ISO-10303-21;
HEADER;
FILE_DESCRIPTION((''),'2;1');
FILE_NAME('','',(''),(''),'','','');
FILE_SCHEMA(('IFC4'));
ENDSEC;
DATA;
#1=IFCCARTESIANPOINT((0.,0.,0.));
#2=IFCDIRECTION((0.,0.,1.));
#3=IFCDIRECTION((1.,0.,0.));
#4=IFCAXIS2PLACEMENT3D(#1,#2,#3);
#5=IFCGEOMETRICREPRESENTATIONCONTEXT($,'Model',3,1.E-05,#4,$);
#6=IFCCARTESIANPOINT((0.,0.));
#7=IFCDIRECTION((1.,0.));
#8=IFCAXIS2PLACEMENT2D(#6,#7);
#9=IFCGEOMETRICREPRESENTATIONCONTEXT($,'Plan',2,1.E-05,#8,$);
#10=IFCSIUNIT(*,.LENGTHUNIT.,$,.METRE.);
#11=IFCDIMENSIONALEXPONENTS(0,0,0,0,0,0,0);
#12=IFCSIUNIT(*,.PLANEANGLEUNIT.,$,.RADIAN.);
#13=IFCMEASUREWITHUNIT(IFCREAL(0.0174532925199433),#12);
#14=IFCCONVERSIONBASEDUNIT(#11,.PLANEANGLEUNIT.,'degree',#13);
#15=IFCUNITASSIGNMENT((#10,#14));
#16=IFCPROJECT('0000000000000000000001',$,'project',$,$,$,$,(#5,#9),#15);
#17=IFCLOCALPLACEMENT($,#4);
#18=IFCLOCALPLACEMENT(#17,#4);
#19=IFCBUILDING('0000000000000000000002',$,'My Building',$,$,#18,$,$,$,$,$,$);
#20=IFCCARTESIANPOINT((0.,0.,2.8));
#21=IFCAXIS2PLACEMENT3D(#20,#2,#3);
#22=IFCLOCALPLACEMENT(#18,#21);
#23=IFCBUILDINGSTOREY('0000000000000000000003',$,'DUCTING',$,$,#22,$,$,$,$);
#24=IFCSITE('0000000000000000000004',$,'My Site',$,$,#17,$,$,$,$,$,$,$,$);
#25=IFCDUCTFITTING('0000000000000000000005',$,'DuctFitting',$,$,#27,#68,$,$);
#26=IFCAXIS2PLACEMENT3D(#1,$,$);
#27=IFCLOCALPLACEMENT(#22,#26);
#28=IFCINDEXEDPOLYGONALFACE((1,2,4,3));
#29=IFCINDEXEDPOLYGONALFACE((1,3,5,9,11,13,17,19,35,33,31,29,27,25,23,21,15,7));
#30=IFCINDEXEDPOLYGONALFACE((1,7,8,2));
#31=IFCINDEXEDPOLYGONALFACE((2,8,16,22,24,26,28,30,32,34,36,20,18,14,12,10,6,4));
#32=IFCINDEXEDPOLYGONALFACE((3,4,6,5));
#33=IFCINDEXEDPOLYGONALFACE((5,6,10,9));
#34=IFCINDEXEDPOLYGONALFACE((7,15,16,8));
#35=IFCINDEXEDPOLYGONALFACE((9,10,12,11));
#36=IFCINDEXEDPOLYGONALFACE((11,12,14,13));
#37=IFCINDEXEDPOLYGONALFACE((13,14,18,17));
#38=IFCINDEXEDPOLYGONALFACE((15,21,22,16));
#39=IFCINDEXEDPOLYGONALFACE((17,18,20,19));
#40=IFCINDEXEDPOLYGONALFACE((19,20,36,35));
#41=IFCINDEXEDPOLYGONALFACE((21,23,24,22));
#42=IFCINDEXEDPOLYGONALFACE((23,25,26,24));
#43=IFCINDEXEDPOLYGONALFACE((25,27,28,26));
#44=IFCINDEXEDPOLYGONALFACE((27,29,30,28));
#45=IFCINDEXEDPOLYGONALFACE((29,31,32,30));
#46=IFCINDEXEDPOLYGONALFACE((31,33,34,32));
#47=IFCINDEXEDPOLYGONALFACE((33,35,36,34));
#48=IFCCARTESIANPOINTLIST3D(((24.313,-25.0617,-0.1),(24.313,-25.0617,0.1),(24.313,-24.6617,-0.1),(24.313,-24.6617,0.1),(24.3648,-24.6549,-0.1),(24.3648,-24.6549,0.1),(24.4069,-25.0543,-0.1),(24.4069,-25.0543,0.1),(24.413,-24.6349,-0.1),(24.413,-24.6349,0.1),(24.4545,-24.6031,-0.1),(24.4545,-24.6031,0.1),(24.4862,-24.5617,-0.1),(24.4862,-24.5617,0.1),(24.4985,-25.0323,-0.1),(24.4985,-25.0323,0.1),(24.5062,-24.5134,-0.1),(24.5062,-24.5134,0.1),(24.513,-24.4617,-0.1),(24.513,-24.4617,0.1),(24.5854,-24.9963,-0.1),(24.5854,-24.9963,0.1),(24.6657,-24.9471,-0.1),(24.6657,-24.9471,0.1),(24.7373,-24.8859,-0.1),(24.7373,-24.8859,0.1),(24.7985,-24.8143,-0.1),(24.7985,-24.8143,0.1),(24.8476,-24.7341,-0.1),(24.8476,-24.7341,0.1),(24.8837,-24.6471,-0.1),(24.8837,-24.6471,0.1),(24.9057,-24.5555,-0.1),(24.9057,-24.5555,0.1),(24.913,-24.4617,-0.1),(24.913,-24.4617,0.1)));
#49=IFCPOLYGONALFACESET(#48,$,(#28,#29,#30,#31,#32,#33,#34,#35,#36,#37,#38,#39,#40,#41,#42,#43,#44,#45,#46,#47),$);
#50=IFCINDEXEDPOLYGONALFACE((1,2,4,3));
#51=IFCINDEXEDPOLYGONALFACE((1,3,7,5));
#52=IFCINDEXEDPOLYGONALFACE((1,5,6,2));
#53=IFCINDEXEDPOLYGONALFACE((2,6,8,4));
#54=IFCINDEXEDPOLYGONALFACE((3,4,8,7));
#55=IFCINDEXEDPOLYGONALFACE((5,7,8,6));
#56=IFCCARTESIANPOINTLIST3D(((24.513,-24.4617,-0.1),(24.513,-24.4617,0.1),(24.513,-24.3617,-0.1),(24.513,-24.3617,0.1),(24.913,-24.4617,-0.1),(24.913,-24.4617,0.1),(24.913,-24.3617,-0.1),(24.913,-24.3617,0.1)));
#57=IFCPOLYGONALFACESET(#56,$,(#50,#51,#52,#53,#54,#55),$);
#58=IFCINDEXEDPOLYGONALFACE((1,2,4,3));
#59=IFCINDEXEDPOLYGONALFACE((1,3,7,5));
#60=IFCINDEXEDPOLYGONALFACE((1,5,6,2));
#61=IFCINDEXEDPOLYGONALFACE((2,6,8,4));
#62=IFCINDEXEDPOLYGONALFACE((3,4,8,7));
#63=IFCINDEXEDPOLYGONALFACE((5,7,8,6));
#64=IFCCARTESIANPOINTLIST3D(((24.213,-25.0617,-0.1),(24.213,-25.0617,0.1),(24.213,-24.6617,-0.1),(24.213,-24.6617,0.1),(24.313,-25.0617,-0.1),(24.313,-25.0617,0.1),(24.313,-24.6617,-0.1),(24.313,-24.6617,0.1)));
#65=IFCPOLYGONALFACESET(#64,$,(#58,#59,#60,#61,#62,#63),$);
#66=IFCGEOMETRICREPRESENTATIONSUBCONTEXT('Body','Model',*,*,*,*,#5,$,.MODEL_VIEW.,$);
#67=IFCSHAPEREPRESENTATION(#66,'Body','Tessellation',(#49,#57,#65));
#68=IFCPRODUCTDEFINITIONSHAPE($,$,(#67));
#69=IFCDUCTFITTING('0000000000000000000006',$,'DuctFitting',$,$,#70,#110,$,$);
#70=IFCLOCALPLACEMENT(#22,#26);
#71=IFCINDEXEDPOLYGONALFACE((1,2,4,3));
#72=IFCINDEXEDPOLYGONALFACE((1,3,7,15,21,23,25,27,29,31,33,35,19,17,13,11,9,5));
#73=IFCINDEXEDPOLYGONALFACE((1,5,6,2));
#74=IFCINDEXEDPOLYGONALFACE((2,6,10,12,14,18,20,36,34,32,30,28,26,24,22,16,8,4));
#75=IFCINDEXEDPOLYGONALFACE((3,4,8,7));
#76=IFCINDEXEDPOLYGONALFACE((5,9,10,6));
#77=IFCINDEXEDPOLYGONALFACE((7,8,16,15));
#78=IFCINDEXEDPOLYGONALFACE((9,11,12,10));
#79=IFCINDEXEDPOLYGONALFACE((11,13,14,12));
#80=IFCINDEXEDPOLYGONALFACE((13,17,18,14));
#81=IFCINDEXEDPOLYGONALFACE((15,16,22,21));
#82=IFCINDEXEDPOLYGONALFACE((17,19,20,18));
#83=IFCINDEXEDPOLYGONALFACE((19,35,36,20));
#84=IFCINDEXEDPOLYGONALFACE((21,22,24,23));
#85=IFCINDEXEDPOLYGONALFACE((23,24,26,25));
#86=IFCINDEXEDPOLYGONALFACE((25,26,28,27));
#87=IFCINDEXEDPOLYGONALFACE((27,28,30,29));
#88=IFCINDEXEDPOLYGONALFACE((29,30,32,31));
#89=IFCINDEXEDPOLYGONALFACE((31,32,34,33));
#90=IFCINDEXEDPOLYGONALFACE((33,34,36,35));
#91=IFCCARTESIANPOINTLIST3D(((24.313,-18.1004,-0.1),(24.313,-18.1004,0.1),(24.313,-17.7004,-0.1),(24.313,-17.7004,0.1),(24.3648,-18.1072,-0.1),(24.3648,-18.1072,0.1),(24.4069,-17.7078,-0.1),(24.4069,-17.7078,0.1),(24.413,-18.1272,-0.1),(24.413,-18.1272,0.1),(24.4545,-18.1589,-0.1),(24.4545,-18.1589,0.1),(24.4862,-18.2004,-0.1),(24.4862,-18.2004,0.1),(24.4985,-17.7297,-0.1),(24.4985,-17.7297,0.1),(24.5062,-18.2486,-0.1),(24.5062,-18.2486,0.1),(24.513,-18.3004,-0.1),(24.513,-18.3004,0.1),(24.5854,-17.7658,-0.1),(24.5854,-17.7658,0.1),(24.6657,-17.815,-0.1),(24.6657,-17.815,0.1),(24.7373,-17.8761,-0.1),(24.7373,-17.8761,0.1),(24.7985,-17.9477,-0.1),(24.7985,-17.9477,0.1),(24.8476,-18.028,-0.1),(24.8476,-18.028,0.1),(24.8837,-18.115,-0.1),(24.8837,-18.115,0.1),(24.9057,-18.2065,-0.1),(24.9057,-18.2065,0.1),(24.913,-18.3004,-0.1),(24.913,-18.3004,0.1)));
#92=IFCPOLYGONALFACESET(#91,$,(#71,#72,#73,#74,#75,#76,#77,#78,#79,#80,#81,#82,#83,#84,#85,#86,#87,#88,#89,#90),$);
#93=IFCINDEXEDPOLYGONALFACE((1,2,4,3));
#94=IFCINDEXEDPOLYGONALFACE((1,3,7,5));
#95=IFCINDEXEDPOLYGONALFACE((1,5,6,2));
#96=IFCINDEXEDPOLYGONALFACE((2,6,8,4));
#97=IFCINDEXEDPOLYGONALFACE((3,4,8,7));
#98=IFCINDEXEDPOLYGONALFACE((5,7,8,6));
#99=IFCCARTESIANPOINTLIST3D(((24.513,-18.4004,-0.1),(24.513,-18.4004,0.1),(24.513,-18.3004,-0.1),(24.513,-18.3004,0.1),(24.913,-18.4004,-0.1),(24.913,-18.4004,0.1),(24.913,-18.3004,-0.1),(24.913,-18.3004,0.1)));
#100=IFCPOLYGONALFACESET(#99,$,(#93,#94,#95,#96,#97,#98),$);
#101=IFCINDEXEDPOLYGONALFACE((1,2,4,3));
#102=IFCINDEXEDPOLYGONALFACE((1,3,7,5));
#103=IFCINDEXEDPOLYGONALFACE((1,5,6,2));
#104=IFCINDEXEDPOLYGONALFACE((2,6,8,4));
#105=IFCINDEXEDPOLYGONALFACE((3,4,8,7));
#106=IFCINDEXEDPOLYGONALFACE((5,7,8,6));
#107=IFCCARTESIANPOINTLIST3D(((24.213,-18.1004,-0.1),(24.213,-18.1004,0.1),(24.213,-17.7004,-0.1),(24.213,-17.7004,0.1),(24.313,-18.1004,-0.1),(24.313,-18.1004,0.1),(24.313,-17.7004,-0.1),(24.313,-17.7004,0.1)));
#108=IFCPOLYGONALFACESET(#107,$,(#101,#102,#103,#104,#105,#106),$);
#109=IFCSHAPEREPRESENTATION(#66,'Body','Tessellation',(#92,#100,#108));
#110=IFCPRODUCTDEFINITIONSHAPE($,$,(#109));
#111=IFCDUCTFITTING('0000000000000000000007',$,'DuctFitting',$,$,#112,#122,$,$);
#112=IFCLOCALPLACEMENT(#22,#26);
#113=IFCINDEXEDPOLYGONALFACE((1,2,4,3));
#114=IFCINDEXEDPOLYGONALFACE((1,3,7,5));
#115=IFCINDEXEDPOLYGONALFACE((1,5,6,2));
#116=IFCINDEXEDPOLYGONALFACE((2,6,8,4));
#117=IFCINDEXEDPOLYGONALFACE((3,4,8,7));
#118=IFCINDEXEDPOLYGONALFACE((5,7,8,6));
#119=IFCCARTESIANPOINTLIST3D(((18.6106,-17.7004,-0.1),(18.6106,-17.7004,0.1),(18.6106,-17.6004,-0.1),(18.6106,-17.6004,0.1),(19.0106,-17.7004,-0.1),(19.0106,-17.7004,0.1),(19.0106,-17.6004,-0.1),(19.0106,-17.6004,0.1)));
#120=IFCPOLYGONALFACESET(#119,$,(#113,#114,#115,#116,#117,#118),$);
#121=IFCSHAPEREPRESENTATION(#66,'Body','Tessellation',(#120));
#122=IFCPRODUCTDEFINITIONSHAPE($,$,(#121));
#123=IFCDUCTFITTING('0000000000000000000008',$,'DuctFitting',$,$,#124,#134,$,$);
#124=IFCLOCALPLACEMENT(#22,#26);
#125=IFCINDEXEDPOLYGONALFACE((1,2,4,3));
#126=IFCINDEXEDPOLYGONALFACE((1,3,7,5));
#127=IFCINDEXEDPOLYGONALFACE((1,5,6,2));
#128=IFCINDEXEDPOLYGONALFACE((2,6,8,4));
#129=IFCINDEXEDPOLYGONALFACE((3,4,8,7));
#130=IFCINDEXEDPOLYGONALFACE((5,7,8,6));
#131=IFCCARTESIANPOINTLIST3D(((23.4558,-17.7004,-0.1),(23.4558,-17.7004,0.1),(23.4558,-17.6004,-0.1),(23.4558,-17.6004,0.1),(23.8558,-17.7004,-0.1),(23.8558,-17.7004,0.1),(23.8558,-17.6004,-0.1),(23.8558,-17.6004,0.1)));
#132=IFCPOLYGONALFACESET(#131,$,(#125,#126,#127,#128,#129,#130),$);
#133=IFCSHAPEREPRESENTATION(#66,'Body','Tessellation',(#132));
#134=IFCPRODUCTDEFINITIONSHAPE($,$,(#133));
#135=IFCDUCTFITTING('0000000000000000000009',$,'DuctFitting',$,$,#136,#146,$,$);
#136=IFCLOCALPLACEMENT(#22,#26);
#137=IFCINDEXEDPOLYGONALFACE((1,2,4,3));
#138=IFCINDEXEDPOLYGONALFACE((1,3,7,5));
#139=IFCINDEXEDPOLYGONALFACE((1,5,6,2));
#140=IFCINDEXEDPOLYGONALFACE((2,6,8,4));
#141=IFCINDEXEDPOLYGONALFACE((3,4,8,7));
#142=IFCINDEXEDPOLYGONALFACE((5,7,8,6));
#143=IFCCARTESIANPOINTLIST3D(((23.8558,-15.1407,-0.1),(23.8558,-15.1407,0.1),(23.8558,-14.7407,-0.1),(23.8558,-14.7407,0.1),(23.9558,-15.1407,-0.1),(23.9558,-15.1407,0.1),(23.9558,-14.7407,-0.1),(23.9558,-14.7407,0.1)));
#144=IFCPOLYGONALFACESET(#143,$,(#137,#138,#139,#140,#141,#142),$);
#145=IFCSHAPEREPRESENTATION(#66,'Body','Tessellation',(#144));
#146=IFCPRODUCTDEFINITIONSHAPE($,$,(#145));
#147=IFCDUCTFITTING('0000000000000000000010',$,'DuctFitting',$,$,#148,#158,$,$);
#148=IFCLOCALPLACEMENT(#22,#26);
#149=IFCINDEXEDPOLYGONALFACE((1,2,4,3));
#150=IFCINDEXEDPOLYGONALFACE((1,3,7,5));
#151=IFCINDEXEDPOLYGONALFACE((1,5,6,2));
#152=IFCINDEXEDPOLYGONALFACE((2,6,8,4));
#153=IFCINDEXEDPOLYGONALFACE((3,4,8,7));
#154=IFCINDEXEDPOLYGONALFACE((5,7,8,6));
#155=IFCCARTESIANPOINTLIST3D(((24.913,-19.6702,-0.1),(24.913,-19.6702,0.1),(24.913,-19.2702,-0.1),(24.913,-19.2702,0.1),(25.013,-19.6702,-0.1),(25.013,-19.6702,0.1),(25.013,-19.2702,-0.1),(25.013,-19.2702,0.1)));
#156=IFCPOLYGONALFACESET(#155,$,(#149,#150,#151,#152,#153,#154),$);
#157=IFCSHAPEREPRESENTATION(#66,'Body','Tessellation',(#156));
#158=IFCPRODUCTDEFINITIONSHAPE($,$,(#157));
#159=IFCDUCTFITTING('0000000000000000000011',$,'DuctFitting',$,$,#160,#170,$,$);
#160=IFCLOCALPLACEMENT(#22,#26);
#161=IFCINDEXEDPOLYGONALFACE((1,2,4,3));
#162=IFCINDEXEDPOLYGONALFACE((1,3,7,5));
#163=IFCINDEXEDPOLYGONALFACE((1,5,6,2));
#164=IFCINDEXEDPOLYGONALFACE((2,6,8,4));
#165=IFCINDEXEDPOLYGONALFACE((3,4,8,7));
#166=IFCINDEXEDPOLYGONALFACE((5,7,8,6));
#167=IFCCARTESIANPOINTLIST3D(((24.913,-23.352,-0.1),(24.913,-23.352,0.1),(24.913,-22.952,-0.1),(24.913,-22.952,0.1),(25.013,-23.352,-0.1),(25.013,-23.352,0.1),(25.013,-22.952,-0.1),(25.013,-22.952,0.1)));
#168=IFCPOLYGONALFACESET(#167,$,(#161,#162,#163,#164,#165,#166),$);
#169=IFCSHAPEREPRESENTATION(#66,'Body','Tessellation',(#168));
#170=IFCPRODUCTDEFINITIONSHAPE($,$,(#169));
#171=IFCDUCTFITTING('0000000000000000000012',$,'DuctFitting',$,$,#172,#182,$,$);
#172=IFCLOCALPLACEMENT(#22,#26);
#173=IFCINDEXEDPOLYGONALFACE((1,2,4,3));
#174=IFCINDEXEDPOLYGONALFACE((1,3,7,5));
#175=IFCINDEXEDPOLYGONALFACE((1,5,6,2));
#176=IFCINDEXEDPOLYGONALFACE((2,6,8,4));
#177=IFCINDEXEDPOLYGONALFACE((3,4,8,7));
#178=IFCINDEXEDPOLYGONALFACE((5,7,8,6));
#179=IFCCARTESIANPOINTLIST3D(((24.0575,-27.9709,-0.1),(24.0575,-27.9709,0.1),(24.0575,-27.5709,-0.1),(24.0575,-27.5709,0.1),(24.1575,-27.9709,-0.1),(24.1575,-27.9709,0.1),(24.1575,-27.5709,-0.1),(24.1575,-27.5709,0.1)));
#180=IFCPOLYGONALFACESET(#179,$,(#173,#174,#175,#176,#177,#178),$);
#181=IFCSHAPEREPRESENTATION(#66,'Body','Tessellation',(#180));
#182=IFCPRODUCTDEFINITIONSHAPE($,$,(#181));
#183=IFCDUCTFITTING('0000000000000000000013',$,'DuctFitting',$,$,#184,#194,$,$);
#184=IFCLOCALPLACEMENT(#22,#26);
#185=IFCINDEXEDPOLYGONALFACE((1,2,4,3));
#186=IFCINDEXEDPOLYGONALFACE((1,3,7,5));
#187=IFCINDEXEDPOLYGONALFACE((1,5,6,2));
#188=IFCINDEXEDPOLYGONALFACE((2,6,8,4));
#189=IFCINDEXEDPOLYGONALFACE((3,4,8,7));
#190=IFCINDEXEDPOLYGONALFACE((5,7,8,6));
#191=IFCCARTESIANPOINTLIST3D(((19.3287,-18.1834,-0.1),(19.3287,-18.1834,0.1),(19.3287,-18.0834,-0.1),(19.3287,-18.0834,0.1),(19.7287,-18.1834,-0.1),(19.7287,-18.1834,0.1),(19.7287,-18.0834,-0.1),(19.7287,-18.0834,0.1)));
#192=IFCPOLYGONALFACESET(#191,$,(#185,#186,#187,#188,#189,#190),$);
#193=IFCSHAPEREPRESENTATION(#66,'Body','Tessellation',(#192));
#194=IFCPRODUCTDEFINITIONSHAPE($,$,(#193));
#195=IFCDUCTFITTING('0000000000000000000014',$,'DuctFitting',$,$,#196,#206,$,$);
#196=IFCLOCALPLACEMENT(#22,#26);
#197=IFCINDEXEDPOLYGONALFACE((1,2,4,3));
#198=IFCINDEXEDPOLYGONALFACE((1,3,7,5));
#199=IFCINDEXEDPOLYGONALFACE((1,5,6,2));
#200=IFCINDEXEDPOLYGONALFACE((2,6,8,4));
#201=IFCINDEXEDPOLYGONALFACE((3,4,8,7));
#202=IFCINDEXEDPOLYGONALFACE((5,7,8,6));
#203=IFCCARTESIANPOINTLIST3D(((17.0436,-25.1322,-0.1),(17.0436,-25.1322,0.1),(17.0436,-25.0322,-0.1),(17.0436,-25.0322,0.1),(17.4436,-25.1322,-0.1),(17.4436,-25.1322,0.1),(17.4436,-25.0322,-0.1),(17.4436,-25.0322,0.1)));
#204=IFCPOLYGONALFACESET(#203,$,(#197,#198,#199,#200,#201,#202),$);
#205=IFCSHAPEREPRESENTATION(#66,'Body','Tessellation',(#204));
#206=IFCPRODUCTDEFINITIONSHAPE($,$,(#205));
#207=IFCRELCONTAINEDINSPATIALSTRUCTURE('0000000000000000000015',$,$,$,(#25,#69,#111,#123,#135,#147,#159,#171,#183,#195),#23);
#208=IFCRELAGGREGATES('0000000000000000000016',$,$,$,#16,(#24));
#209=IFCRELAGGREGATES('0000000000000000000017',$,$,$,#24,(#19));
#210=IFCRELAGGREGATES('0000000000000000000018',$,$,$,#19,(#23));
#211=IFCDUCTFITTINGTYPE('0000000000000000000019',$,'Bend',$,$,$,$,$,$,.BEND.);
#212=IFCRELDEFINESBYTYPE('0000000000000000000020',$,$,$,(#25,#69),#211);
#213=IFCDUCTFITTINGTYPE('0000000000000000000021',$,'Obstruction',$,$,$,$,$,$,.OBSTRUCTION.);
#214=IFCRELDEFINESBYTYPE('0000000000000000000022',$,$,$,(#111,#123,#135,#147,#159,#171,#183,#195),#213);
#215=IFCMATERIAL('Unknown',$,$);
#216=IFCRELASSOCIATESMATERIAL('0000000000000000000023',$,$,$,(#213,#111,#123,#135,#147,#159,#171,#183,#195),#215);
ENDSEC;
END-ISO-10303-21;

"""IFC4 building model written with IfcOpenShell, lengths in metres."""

from ifc_helpers import new_model, entity, si_unit, converted_unit, frame, origin_with_axes, origin_2d_with_axis, place, context, subcontext, project, spatial, line, arc, indexed_curve, rectangle, outline, extrude, source, transform, mapped, material, material_profile, profile_set, profile_usage, type_object, type_shapes, element, save


model = new_model("IFC4")

# Units and contexts
model_context = context("Model", 3, precision=1e-05, world=origin_with_axes())
plan_context = context("Plan", 2, precision=1e-05, world=origin_2d_with_axis())
body_context = subcontext(model_context, "Body", "Model", "MODEL_VIEW")
ifc_project = project(units=[si_unit("LENGTHUNIT", "METRE"), converted_unit("PLANEANGLEUNIT", "degree", entity("IfcReal", 0.0174532925199433), si_unit("PLANEANGLEUNIT", "RADIAN"), dimensions=[0, 0, 0, 0, 0, 0, 0])], contexts=[model_context, plan_context])

# Site, building, storey
site_placement = place(None, origin_with_axes())
site = spatial("IfcSite", under=ifc_project, at=site_placement, Name="My Site")
building_placement = place(site_placement, origin_with_axes())
building = spatial("IfcBuilding", under=site, at=building_placement, Name="My Building")
storey_placement = place(building_placement, frame((0.0, 0.0, 2.8), z_axis=(0.0, 0.0, 1.0), x_axis=(1.0, 0.0, 0.0)))
storey = spatial("IfcBuildingStorey", under=building, at=storey_placement, Name="DUCTING")

# Shared definitions
ifc_material = material(Name="Unknown")

# Duct fittings
duct_fitting_type_1 = type_object("IfcDuctFittingType", Name="Bend", PredefinedType="BEND")
shared_shape = source(origin_with_axes(), body_context, "Body", "SweptSolid", [
    extrude(outline(indexed_curve([(-0.2, 0.0), (-0.2586, 0.1414), (-0.4, 0.2), (-0.4, 0.6), (0.0243, 0.4243), (0.2, 0.0)], segments=[arc(1, 2, 3), line(3, 4), arc(4, 5, 6), line(6, 1)])), frame((0.0, -0.1, 0.1), z_axis=(0.0, -1.0, 0.0), x_axis=(1.0, 0.0, 0.0)), (0.0, 0.0, -1.0), 0.2),
    extrude(rectangle(XDim=0.4, YDim=0.2), origin_with_axes(), (0.0, 0.0, 1.0), 0.1),
    extrude(rectangle(XDim=0.4, YDim=0.2), frame((-0.4, 0.0, 0.5), z_axis=(-1.0, 0.0, 0.0), x_axis=(0.0, 0.0, -1.0)), (0.0, 0.0, 1.0), 0.1),
])
type_shapes(duct_fitting_type_1, [shared_shape])
for number, where, z_axis, x_axis, name in (
    (1, (24.713, -24.3617, 0.0), (0.0, -1.0, 0.0), (1.0, 0.0, 0.0), "DuctFitting"),
    (2, (24.713, -18.4004, 0.0), (0.0, 1.0, 0.0), (1.0, 0.0, 0.0), "DuctFitting"),
):
    element("IfcDuctFitting", number, at=place(storey_placement, frame(where, z_axis=z_axis, x_axis=x_axis)), inside=storey, type_object=duct_fitting_type_1, Name=name, context=body_context, shape_type="MappedRepresentation", body=[
        mapped(shared_shape, transform((0.0, 0.0, 0.0), x_axis=(1.0, 0.0, 0.0), y_axis=(0.0, 1.0, 0.0), z_axis=(0.0, 0.0, 1.0), scale=1.0)),
    ])
ifc_material_profile_1 = material_profile(ifc_material, rectangle(XDim=0.4, YDim=0.2))
ifc_profile_set_1 = profile_set([ifc_material_profile_1])
ifc_profile_usage_1 = profile_usage(ifc_profile_set_1, cardinal=5)
duct_fitting_type_2 = type_object("IfcDuctFittingType", Name="Obstruction", PredefinedType="OBSTRUCTION", material=ifc_profile_set_1)
duct_fitting_1_placement = place(storey_placement, frame((18.8106, -17.7004, 0.0), z_axis=(0.0, 1.0, 0.0), x_axis=(-1.0, 0.0, 0.0)))
element("IfcDuctFitting", 3, at=duct_fitting_1_placement, inside=storey, type_object=duct_fitting_type_2, material=ifc_profile_usage_1, Name="DuctFitting", context=body_context, shape_type="SweptSolid", body=[
    extrude(rectangle(XDim=0.4, YDim=0.2), origin_with_axes(), (0.0, 0.0, 1.0), 0.1),
])
ifc_profile_usage_2 = profile_usage(ifc_profile_set_1, cardinal=5)
duct_fitting_2_placement = place(storey_placement, frame((23.6558, -17.7004, 0.0), z_axis=(0.0, 1.0, 0.0), x_axis=(-1.0, 0.0, 0.0)))
element("IfcDuctFitting", 4, at=duct_fitting_2_placement, inside=storey, type_object=duct_fitting_type_2, material=ifc_profile_usage_2, Name="DuctFitting", context=body_context, shape_type="SweptSolid", body=[
    extrude(rectangle(XDim=0.4, YDim=0.2), origin_with_axes(), (0.0, 0.0, 1.0), 0.1),
])
ifc_profile_usage_3 = profile_usage(ifc_profile_set_1, cardinal=5)
duct_fitting_3_placement = place(storey_placement, frame((23.8558, -14.9407, 0.0), z_axis=(1.0, 0.0, 0.0), x_axis=(0.0, 1.0, 0.0)))
element("IfcDuctFitting", 5, at=duct_fitting_3_placement, inside=storey, type_object=duct_fitting_type_2, material=ifc_profile_usage_3, Name="DuctFitting", context=body_context, shape_type="SweptSolid", body=[
    extrude(rectangle(XDim=0.4, YDim=0.2), origin_with_axes(), (0.0, 0.0, 1.0), 0.1),
])
ifc_profile_usage_4 = profile_usage(ifc_profile_set_1, cardinal=5)
duct_fitting_4_placement = place(storey_placement, frame((24.913, -19.4702, 0.0), z_axis=(1.0, 0.000001, -0.000001), x_axis=(-0.000001, 1.0, 0.0)))
element("IfcDuctFitting", 6, at=duct_fitting_4_placement, inside=storey, type_object=duct_fitting_type_2, material=ifc_profile_usage_4, Name="DuctFitting", context=body_context, shape_type="SweptSolid", body=[
    extrude(rectangle(XDim=0.4, YDim=0.2), origin_with_axes(), (0.0, 0.0, 1.0), 0.1),
])
ifc_profile_usage_5 = profile_usage(ifc_profile_set_1, cardinal=5)
duct_fitting_5_placement = place(storey_placement, frame((24.913, -23.152, 0.0), z_axis=(1.0, 0.000001, -0.000001), x_axis=(-0.000001, 1.0, 0.0)))
element("IfcDuctFitting", 7, at=duct_fitting_5_placement, inside=storey, type_object=duct_fitting_type_2, material=ifc_profile_usage_5, Name="DuctFitting", context=body_context, shape_type="SweptSolid", body=[
    extrude(rectangle(XDim=0.4, YDim=0.2), origin_with_axes(), (0.0, 0.0, 1.0), 0.1),
])
ifc_profile_usage_6 = profile_usage(ifc_profile_set_1, cardinal=5)
duct_fitting_6_placement = place(storey_placement, frame((24.0575, -27.7709, 0.0), z_axis=(1.0, 0.0, 0.0), x_axis=(0.0, 1.0, 0.0)))
element("IfcDuctFitting", 8, at=duct_fitting_6_placement, inside=storey, type_object=duct_fitting_type_2, material=ifc_profile_usage_6, Name="DuctFitting", context=body_context, shape_type="SweptSolid", body=[
    extrude(rectangle(XDim=0.4, YDim=0.2), origin_with_axes(), (0.0, 0.0, 1.0), 0.1),
])
ifc_profile_usage_7 = profile_usage(ifc_profile_set_1, cardinal=5)
duct_fitting_7_placement = place(storey_placement, frame((19.5287, -18.1834, 0.0), z_axis=(-0.000001, 1.0, 0.0), x_axis=(-1.0, -0.000001, 0.0)))
element("IfcDuctFitting", 9, at=duct_fitting_7_placement, inside=storey, type_object=duct_fitting_type_2, material=ifc_profile_usage_7, Name="DuctFitting", context=body_context, shape_type="SweptSolid", body=[
    extrude(rectangle(XDim=0.4, YDim=0.2), origin_with_axes(), (0.0, 0.0, 1.0), 0.1),
])
ifc_profile_usage_8 = profile_usage(ifc_profile_set_1, cardinal=5)
duct_fitting_8_placement = place(storey_placement, frame((17.2436, -25.1322, 0.0), z_axis=(0.0, 1.0, 0.0), x_axis=(-1.0, 0.0, 0.0)))
element("IfcDuctFitting", 10, at=duct_fitting_8_placement, inside=storey, type_object=duct_fitting_type_2, material=ifc_profile_usage_8, Name="DuctFitting", context=body_context, shape_type="SweptSolid", body=[
    extrude(rectangle(XDim=0.4, YDim=0.2), origin_with_axes(), (0.0, 0.0, 1.0), 0.1),
])

save(model, "model.ifc")
